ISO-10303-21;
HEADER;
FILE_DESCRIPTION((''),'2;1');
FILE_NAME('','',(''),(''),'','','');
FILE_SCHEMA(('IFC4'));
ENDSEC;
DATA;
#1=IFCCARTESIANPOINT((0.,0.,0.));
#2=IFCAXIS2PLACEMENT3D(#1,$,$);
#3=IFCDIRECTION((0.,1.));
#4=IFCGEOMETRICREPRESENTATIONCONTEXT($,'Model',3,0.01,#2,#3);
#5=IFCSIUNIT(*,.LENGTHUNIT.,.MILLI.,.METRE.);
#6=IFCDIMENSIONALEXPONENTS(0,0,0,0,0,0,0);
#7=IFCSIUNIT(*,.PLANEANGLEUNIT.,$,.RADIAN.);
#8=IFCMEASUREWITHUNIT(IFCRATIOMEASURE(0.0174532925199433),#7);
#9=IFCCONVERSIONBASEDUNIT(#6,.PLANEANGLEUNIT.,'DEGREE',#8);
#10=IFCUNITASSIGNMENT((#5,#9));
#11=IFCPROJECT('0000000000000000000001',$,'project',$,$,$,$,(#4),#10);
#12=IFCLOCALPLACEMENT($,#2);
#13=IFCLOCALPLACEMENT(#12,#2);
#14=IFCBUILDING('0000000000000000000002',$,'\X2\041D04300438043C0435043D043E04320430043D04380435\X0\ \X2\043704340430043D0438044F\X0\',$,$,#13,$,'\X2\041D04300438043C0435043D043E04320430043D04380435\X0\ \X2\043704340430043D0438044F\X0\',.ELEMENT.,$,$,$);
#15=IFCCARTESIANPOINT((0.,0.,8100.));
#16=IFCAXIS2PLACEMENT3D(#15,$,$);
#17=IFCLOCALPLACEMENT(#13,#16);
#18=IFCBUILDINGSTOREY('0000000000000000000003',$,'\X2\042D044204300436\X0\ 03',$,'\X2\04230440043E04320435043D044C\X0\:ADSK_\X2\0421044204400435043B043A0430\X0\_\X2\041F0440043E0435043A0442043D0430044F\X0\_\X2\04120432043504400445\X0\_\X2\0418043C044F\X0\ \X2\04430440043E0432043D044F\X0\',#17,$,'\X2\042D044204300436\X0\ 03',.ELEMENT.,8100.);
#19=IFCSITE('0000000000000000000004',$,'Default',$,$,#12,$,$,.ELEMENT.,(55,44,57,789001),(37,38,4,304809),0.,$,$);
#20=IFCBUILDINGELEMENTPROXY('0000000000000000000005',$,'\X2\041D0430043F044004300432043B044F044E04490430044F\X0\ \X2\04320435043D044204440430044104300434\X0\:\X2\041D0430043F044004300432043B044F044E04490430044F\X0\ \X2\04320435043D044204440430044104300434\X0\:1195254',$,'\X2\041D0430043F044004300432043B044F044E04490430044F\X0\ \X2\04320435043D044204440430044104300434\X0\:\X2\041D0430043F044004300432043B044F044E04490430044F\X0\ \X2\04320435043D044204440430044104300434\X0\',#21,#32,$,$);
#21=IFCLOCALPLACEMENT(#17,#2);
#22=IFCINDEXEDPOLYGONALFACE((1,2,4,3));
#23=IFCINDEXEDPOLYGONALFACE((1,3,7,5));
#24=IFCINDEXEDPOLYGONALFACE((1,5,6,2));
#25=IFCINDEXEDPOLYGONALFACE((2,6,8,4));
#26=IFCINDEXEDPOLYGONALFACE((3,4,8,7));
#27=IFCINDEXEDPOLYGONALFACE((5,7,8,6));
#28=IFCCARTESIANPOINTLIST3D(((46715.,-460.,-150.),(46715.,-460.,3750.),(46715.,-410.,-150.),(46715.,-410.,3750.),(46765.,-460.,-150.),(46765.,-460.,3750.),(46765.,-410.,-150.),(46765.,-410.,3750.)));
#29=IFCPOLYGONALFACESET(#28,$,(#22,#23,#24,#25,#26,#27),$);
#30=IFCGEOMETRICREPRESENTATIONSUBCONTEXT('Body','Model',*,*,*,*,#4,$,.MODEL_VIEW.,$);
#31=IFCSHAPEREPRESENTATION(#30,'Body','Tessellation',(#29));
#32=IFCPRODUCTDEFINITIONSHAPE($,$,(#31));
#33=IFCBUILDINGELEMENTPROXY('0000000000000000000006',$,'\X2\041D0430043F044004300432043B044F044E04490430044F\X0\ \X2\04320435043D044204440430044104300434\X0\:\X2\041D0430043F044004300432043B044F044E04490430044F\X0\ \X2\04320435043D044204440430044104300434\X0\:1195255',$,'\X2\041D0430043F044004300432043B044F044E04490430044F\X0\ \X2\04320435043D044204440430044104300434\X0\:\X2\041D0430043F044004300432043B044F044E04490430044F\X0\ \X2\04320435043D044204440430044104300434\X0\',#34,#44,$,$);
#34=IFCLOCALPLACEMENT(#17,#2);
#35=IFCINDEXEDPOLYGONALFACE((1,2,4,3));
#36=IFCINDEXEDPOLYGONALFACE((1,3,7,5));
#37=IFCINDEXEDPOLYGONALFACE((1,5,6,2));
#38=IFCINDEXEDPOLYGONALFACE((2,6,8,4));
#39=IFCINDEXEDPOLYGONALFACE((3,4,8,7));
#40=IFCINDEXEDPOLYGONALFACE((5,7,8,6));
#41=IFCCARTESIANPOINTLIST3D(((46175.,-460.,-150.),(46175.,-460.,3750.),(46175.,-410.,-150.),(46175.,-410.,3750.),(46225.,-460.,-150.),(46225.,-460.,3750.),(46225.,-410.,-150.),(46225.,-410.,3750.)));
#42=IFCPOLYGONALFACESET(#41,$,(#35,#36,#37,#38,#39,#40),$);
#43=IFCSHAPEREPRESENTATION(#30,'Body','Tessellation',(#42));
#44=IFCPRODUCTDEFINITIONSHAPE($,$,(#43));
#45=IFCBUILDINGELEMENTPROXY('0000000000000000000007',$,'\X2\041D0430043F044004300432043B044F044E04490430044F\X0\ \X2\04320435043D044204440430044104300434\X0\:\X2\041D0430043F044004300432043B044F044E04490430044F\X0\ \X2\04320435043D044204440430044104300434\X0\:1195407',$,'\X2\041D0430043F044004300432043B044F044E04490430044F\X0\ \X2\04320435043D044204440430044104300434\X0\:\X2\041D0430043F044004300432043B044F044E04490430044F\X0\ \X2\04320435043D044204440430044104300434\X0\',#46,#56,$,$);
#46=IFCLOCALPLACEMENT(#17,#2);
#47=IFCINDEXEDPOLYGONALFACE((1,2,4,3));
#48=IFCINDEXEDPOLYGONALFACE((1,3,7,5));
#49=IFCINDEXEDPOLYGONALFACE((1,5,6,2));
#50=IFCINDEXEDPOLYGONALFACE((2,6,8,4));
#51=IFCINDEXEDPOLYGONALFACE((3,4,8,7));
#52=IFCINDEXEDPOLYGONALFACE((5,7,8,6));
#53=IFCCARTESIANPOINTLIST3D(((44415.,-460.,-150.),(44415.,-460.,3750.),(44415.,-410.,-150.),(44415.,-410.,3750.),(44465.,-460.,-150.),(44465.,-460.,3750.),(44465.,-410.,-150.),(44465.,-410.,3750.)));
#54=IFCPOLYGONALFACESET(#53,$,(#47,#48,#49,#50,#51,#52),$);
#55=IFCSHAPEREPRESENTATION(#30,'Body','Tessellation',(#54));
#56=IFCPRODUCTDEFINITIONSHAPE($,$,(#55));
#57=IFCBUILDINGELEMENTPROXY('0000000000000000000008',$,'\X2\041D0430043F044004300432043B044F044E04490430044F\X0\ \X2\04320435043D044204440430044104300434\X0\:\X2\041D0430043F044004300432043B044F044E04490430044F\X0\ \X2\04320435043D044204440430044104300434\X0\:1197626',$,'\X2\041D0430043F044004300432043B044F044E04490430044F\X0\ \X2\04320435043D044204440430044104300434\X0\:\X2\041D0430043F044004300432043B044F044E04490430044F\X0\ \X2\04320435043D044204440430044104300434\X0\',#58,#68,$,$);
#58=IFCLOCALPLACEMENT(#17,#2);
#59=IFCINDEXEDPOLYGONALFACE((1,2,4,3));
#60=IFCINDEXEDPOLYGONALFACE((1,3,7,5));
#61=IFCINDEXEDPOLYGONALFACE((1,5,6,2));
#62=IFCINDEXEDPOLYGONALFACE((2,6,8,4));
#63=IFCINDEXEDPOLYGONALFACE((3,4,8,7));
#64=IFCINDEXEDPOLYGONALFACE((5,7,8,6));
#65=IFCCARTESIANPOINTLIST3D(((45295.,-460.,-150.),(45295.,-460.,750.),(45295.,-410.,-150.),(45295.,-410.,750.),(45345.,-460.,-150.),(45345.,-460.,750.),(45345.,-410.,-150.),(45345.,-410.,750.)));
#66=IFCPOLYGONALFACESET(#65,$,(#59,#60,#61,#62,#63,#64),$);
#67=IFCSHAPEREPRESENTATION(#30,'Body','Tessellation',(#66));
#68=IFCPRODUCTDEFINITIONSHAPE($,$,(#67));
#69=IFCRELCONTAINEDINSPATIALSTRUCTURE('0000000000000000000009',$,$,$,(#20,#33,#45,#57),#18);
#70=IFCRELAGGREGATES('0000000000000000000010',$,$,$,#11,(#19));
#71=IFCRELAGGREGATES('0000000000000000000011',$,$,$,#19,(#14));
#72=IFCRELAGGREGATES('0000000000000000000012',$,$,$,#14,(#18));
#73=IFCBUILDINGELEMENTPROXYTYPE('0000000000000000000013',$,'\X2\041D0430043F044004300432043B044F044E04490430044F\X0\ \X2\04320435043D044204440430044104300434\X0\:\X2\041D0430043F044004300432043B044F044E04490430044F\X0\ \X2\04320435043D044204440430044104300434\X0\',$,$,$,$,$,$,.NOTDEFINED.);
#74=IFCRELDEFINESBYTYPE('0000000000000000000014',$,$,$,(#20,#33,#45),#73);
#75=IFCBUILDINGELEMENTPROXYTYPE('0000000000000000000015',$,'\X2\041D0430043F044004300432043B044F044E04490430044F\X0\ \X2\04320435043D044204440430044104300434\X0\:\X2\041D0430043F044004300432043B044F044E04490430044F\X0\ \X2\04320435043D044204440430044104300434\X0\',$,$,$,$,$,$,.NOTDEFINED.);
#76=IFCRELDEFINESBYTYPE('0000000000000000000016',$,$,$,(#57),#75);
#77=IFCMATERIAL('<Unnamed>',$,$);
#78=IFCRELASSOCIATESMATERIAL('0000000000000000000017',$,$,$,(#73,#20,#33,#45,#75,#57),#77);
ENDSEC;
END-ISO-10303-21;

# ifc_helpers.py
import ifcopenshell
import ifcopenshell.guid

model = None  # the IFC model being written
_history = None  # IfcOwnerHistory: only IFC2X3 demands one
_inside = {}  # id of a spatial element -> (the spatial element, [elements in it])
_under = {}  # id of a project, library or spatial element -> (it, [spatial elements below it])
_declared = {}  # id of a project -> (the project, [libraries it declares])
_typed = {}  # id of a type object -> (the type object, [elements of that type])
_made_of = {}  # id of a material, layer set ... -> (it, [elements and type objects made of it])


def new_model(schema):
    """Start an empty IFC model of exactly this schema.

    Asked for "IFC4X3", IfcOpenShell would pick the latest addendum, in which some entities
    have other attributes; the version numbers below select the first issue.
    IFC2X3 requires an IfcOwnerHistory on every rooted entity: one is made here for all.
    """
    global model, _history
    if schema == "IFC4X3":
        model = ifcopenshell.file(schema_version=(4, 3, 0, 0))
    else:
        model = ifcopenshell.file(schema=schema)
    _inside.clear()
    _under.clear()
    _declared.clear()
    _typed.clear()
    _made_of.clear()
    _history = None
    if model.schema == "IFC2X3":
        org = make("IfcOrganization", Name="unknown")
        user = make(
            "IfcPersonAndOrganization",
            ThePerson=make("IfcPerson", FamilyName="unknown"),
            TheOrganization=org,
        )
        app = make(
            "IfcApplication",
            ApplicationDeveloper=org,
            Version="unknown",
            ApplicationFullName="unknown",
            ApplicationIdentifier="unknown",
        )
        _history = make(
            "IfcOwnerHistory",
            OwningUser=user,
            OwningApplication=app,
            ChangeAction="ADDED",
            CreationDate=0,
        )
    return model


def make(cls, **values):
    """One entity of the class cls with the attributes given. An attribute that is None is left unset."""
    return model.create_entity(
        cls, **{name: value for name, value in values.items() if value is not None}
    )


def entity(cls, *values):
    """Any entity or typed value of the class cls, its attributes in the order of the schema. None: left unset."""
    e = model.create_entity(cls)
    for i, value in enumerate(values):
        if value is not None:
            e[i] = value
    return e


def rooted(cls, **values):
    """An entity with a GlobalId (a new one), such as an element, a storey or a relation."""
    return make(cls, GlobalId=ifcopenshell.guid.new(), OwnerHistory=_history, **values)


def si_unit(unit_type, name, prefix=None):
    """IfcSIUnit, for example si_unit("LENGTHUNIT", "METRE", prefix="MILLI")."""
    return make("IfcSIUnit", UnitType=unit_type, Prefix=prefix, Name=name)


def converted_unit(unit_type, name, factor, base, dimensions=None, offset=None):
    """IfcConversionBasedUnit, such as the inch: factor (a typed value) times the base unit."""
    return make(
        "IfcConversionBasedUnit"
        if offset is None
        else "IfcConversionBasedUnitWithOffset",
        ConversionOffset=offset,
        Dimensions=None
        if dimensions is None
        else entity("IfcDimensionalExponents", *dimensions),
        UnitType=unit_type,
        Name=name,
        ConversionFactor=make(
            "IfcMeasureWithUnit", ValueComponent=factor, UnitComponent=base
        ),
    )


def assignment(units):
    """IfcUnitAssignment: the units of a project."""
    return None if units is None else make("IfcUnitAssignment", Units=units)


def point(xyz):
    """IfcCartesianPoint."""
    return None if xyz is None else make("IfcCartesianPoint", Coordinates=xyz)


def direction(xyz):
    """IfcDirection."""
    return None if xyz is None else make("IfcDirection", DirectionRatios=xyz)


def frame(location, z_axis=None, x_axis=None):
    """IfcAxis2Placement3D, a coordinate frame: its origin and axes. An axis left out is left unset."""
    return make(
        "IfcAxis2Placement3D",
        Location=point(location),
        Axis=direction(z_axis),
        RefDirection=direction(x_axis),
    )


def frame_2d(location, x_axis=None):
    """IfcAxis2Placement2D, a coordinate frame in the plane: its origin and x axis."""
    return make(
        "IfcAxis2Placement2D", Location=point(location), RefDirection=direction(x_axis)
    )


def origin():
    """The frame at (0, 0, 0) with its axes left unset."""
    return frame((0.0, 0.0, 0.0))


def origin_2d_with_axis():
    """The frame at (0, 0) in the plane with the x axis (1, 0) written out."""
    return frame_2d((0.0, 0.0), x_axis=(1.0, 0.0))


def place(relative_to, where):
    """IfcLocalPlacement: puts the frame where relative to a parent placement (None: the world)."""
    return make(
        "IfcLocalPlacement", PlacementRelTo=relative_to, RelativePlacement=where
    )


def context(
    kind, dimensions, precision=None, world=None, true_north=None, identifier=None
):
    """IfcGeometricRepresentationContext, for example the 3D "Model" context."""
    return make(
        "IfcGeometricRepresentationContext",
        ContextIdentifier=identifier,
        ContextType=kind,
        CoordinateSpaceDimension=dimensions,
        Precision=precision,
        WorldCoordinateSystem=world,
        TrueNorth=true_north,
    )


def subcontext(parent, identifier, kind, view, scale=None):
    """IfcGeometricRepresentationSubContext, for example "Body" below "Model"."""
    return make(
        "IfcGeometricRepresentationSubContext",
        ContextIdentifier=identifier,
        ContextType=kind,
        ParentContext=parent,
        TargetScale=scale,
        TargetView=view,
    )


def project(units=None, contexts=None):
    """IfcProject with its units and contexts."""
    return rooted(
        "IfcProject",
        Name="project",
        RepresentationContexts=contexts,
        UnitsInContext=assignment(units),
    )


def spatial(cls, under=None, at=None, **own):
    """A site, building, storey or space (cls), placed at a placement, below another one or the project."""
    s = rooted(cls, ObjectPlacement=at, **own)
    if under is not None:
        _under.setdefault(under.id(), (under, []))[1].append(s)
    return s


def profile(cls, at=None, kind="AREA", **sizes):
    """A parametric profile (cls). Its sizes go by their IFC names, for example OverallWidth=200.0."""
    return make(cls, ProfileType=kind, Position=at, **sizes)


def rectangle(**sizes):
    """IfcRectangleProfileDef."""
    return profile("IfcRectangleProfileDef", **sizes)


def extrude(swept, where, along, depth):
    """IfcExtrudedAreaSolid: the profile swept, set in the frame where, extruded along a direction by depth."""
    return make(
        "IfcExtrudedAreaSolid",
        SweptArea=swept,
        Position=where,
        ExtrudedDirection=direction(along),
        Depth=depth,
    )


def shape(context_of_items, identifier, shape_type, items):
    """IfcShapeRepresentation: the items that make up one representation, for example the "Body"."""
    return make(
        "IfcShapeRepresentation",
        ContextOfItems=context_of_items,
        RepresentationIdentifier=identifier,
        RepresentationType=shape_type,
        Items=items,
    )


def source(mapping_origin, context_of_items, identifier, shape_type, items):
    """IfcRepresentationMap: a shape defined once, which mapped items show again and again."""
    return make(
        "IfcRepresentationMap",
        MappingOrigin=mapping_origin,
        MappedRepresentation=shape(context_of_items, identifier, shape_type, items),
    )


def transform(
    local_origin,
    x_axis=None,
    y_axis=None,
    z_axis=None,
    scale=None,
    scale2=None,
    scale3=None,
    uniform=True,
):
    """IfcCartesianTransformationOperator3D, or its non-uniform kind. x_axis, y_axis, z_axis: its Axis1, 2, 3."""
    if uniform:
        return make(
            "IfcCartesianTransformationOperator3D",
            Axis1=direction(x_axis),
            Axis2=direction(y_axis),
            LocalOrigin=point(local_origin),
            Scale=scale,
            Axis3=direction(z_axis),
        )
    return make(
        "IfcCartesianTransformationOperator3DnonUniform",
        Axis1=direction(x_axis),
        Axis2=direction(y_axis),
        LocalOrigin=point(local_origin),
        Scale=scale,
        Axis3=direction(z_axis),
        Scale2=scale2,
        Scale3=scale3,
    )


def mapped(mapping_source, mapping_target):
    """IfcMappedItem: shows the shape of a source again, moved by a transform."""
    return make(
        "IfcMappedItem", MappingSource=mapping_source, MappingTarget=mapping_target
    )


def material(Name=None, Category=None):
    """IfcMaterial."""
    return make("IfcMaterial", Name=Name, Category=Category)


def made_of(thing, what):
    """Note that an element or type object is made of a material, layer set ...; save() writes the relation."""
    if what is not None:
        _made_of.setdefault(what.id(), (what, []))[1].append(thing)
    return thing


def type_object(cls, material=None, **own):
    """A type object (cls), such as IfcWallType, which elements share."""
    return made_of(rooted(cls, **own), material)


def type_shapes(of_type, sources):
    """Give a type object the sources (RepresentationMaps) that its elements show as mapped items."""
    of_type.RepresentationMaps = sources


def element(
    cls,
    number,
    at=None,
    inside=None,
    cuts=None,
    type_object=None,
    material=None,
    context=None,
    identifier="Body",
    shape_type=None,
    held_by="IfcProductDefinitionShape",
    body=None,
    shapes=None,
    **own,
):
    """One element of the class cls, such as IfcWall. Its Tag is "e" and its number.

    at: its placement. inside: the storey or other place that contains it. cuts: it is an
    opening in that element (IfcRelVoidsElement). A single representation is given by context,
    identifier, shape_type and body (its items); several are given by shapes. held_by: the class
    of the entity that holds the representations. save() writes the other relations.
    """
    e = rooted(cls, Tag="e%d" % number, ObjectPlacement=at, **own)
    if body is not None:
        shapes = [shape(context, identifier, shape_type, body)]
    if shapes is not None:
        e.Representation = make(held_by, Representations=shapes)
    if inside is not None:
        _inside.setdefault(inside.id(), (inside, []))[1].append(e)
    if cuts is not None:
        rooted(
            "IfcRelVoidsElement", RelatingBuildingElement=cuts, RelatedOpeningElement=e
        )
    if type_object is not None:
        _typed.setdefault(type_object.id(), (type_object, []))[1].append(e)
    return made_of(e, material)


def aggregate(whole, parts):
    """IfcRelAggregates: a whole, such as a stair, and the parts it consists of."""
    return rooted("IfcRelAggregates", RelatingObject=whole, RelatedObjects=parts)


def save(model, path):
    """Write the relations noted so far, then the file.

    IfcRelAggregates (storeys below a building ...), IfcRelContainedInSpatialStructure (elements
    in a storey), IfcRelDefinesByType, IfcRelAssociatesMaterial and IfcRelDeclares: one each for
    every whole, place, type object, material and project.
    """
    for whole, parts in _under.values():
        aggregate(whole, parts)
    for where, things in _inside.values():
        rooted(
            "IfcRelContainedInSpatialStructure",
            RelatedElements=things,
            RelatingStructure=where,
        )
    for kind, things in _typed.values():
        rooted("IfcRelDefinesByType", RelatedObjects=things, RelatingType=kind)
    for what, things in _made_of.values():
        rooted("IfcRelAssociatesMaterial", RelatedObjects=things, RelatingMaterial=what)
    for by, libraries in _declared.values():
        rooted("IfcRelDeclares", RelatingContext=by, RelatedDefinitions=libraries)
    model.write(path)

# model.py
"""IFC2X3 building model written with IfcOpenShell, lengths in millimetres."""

from ifc_helpers import new_model, entity, si_unit, converted_unit, direction, frame, origin, origin_2d_with_axis, place, context, subcontext, project, spatial, rectangle, extrude, source, transform, mapped, material, type_object, type_shapes, element, save


model = new_model("IFC2X3")

# Units and contexts
model_context = context("Model", 3, precision=0.01, world=origin(), true_north=direction((0.0, 1.0)))
body_context = subcontext(model_context, "Body", "Model", "MODEL_VIEW")
ifc_project = project(units=[si_unit("LENGTHUNIT", "METRE", prefix="MILLI"), converted_unit("PLANEANGLEUNIT", "DEGREE", entity("IfcRatioMeasure", 0.0174532925199433), si_unit("PLANEANGLEUNIT", "RADIAN"), dimensions=[0, 0, 0, 0, 0, 0, 0])], contexts=[model_context])

# Site, building, storey
site_placement = place(None, origin())
site = spatial("IfcSite", under=ifc_project, at=site_placement, Name="Default", CompositionType="ELEMENT", RefLatitude=(55, 44, 57, 789001), RefLongitude=(37, 38, 4, 304809), RefElevation=0.0)
building_placement = place(site_placement, origin())
building = spatial("IfcBuilding", under=site, at=building_placement, Name="Наименование здания", LongName="Наименование здания", CompositionType="ELEMENT")
storey_placement = place(building_placement, frame((0.0, 0.0, 8100.0)))
storey = spatial("IfcBuildingStorey", under=building, at=storey_placement, Name="Этаж 03", ObjectType="Уровень:ADSK_Стрелка_Проектная_Вверх_Имя уровня", LongName="Этаж 03", CompositionType="ELEMENT", Elevation=8100.0)

# Building element proxies
ifc_material_1 = material(Name="<Unnamed>")
building_element_proxy_type_1 = type_object("IfcBuildingElementProxyType", Name="Направляющая вентфасад:Направляющая вентфасад", PredefinedType="NOTDEFINED", material=ifc_material_1)
shared_shape_1 = source(origin(), body_context, "Body", "SweptSolid", [
    extrude(rectangle(XDim=50.0, YDim=50.0, at=origin_2d_with_axis()), frame((25.0, -25.0, 0.0), z_axis=(0.0, 0.0, 1.0), x_axis=(-1.0, 0.0, 0.0)), (0.0, 0.0, 1.0), 3900.0),
])
type_shapes(building_element_proxy_type_1, [shared_shape_1])
for number, where, name in (
    (1, (46715.0, -410.0, -150.0), "Направляющая вентфасад:Направляющая вентфасад:1195254"),
    (2, (46175.0, -410.0, -150.0), "Направляющая вентфасад:Направляющая вентфасад:1195255"),
    (3, (44415.0, -410.0, -150.0), "Направляющая вентфасад:Направляющая вентфасад:1195407"),
):
    element("IfcBuildingElementProxy", number, at=place(storey_placement, frame(where)), inside=storey, type_object=building_element_proxy_type_1, material=ifc_material_1, Name=name, ObjectType="Направляющая вентфасад:Направляющая вентфасад", context=body_context, shape_type="MappedRepresentation", body=[
        mapped(shared_shape_1, transform((0.0, 0.0, 0.0), scale=1.0)),
    ])
building_element_proxy_type_2 = type_object("IfcBuildingElementProxyType", Name="Направляющая вентфасад:Направляющая вентфасад", PredefinedType="NOTDEFINED", material=ifc_material_1)
shared_shape_2 = source(origin(), body_context, "Body", "SweptSolid", [
    extrude(rectangle(XDim=50.0, YDim=50.0, at=origin_2d_with_axis()), frame((25.0, -25.0, 0.0), z_axis=(0.0, 0.0, 1.0), x_axis=(-1.0, 0.0, 0.0)), (0.0, 0.0, 1.0), 900.0),
])
type_shapes(building_element_proxy_type_2, [shared_shape_2])
proxy_placement = place(storey_placement, frame((45295.0, -410.0, -150.0)))
element("IfcBuildingElementProxy", 4, at=proxy_placement, inside=storey, type_object=building_element_proxy_type_2, material=ifc_material_1, Name="Направляющая вентфасад:Направляющая вентфасад:1197626", ObjectType="Направляющая вентфасад:Направляющая вентфасад", context=body_context, shape_type="MappedRepresentation", body=[
    mapped(shared_shape_2, transform((0.0, 0.0, 0.0), scale=1.0)),
])

save(model, "model.ifc")
